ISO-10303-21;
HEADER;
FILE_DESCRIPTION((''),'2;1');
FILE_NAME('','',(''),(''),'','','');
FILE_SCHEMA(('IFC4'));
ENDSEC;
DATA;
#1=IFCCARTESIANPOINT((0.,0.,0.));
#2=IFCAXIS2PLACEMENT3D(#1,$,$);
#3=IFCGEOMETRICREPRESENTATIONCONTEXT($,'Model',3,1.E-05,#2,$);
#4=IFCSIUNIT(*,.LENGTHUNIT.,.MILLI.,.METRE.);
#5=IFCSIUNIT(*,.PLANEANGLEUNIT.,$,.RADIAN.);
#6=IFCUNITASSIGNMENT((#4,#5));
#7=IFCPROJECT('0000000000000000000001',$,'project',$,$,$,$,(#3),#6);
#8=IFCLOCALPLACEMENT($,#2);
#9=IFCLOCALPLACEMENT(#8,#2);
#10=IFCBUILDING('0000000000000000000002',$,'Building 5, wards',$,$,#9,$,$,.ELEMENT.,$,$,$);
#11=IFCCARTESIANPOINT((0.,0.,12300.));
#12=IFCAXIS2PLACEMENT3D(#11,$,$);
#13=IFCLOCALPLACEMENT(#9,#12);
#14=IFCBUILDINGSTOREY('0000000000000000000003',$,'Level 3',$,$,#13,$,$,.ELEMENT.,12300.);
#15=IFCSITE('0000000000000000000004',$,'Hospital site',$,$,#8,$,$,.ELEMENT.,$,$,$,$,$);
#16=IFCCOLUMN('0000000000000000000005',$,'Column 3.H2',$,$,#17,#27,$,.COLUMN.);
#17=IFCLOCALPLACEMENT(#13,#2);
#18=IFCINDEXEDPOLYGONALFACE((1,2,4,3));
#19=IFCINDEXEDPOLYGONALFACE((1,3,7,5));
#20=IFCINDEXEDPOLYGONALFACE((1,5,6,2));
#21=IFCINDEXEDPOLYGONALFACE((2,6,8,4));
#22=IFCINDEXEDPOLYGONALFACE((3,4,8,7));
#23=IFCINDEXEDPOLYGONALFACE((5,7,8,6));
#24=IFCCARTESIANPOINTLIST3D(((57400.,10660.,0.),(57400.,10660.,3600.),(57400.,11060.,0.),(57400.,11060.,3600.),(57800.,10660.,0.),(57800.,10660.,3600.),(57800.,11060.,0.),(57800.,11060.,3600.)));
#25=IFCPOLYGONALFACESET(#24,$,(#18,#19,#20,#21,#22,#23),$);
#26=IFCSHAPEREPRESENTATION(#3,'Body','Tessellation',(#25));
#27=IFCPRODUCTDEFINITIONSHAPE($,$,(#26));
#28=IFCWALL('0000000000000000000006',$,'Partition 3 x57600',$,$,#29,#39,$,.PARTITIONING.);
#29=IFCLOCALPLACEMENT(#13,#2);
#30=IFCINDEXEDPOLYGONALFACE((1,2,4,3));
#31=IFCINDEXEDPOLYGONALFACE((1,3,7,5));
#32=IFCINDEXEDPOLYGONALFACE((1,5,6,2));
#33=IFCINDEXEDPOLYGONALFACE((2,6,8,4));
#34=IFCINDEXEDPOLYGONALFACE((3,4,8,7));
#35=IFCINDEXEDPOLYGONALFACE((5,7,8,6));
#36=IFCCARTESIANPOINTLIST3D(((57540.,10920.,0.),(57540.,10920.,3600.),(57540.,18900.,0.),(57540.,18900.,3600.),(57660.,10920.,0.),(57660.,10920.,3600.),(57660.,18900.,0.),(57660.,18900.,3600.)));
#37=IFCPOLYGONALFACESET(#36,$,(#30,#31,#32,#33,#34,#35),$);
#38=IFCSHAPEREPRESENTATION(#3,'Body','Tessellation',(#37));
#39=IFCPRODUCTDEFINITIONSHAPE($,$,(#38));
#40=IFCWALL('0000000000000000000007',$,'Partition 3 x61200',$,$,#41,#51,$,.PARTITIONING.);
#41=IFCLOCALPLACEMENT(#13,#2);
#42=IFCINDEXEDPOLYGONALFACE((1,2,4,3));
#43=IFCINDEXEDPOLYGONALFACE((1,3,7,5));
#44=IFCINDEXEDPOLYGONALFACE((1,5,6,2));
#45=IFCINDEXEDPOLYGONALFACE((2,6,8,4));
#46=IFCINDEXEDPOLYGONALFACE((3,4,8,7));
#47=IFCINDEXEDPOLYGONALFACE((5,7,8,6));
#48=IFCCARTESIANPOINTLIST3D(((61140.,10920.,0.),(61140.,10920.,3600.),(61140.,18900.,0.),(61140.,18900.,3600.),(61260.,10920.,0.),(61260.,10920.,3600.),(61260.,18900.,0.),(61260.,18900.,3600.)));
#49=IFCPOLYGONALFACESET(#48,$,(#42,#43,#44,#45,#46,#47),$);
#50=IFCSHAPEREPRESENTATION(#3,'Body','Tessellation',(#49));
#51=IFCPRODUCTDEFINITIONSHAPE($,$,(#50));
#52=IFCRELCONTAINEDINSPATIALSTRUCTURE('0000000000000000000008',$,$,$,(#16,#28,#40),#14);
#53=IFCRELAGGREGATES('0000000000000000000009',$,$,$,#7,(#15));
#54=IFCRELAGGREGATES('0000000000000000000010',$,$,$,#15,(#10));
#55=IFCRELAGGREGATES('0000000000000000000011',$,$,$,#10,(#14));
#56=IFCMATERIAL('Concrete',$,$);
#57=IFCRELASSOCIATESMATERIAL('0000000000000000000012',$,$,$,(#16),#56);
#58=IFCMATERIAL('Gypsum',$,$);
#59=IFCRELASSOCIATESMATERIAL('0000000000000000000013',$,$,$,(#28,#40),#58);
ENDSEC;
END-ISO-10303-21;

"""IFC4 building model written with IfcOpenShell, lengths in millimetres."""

from ifc_helpers import new_model, si_unit, frame, frame_2d, origin, origin_2d, place, context, project, spatial, rectangle, extrude, material, element, save


model = new_model("IFC4")

# Units and contexts
model_context = context("Model", 3, precision=1e-05, world=origin())
ifc_project = project(units=[si_unit("LENGTHUNIT", "METRE", prefix="MILLI"), si_unit("PLANEANGLEUNIT", "RADIAN")], contexts=[model_context])

# Site, building, storey
site_placement = place(None, origin())
site = spatial("IfcSite", under=ifc_project, at=site_placement, Name="Hospital site", CompositionType="ELEMENT")
building_placement = place(site_placement, origin())
building = spatial("IfcBuilding", under=site, at=building_placement, Name="Building 5, wards", CompositionType="ELEMENT")
storey_placement = place(building_placement, frame((0.0, 0.0, 12300.0)))
storey = spatial("IfcBuildingStorey", under=building, at=storey_placement, Name="Level 3", CompositionType="ELEMENT", Elevation=12300.0)

# Column
ifc_material_1 = material(Name="Concrete")
column_placement = place(storey_placement, frame((57600.0, 10860.0, 0.0)))
element("IfcColumn", 1, at=column_placement, inside=storey, material=ifc_material_1, Name="Column 3.H2", PredefinedType="COLUMN", context=model_context, shape_type="SweptSolid", body=[
    extrude(rectangle(XDim=400.0, YDim=400.0, at=origin_2d()), origin(), (0.0, 0.0, 1.0), 3600.0),
])

# Walls
ifc_material_2 = material(Name="Gypsum")
for number, where, x_axis, name in (
    (2, (57660.0, 10920.0, 0.0), (0.0, 1.0, 0.0), "Partition 3 x57600"),
    (3, (61260.0, 10920.0, 0.0), (0.0, 1.0, 0.0), "Partition 3 x61200"),
):
    element("IfcWall", number, at=place(storey_placement, frame(where, x_axis=x_axis)), inside=storey, material=ifc_material_2, Name=name, PredefinedType="PARTITIONING", context=model_context, shape_type="SweptSolid", body=[
        extrude(rectangle(XDim=7980.0, YDim=120.0, at=frame_2d((3990.0, 60.0))), origin(), (0.0, 0.0, 1.0), 3600.0),
    ])

save(model, "model.ifc")
